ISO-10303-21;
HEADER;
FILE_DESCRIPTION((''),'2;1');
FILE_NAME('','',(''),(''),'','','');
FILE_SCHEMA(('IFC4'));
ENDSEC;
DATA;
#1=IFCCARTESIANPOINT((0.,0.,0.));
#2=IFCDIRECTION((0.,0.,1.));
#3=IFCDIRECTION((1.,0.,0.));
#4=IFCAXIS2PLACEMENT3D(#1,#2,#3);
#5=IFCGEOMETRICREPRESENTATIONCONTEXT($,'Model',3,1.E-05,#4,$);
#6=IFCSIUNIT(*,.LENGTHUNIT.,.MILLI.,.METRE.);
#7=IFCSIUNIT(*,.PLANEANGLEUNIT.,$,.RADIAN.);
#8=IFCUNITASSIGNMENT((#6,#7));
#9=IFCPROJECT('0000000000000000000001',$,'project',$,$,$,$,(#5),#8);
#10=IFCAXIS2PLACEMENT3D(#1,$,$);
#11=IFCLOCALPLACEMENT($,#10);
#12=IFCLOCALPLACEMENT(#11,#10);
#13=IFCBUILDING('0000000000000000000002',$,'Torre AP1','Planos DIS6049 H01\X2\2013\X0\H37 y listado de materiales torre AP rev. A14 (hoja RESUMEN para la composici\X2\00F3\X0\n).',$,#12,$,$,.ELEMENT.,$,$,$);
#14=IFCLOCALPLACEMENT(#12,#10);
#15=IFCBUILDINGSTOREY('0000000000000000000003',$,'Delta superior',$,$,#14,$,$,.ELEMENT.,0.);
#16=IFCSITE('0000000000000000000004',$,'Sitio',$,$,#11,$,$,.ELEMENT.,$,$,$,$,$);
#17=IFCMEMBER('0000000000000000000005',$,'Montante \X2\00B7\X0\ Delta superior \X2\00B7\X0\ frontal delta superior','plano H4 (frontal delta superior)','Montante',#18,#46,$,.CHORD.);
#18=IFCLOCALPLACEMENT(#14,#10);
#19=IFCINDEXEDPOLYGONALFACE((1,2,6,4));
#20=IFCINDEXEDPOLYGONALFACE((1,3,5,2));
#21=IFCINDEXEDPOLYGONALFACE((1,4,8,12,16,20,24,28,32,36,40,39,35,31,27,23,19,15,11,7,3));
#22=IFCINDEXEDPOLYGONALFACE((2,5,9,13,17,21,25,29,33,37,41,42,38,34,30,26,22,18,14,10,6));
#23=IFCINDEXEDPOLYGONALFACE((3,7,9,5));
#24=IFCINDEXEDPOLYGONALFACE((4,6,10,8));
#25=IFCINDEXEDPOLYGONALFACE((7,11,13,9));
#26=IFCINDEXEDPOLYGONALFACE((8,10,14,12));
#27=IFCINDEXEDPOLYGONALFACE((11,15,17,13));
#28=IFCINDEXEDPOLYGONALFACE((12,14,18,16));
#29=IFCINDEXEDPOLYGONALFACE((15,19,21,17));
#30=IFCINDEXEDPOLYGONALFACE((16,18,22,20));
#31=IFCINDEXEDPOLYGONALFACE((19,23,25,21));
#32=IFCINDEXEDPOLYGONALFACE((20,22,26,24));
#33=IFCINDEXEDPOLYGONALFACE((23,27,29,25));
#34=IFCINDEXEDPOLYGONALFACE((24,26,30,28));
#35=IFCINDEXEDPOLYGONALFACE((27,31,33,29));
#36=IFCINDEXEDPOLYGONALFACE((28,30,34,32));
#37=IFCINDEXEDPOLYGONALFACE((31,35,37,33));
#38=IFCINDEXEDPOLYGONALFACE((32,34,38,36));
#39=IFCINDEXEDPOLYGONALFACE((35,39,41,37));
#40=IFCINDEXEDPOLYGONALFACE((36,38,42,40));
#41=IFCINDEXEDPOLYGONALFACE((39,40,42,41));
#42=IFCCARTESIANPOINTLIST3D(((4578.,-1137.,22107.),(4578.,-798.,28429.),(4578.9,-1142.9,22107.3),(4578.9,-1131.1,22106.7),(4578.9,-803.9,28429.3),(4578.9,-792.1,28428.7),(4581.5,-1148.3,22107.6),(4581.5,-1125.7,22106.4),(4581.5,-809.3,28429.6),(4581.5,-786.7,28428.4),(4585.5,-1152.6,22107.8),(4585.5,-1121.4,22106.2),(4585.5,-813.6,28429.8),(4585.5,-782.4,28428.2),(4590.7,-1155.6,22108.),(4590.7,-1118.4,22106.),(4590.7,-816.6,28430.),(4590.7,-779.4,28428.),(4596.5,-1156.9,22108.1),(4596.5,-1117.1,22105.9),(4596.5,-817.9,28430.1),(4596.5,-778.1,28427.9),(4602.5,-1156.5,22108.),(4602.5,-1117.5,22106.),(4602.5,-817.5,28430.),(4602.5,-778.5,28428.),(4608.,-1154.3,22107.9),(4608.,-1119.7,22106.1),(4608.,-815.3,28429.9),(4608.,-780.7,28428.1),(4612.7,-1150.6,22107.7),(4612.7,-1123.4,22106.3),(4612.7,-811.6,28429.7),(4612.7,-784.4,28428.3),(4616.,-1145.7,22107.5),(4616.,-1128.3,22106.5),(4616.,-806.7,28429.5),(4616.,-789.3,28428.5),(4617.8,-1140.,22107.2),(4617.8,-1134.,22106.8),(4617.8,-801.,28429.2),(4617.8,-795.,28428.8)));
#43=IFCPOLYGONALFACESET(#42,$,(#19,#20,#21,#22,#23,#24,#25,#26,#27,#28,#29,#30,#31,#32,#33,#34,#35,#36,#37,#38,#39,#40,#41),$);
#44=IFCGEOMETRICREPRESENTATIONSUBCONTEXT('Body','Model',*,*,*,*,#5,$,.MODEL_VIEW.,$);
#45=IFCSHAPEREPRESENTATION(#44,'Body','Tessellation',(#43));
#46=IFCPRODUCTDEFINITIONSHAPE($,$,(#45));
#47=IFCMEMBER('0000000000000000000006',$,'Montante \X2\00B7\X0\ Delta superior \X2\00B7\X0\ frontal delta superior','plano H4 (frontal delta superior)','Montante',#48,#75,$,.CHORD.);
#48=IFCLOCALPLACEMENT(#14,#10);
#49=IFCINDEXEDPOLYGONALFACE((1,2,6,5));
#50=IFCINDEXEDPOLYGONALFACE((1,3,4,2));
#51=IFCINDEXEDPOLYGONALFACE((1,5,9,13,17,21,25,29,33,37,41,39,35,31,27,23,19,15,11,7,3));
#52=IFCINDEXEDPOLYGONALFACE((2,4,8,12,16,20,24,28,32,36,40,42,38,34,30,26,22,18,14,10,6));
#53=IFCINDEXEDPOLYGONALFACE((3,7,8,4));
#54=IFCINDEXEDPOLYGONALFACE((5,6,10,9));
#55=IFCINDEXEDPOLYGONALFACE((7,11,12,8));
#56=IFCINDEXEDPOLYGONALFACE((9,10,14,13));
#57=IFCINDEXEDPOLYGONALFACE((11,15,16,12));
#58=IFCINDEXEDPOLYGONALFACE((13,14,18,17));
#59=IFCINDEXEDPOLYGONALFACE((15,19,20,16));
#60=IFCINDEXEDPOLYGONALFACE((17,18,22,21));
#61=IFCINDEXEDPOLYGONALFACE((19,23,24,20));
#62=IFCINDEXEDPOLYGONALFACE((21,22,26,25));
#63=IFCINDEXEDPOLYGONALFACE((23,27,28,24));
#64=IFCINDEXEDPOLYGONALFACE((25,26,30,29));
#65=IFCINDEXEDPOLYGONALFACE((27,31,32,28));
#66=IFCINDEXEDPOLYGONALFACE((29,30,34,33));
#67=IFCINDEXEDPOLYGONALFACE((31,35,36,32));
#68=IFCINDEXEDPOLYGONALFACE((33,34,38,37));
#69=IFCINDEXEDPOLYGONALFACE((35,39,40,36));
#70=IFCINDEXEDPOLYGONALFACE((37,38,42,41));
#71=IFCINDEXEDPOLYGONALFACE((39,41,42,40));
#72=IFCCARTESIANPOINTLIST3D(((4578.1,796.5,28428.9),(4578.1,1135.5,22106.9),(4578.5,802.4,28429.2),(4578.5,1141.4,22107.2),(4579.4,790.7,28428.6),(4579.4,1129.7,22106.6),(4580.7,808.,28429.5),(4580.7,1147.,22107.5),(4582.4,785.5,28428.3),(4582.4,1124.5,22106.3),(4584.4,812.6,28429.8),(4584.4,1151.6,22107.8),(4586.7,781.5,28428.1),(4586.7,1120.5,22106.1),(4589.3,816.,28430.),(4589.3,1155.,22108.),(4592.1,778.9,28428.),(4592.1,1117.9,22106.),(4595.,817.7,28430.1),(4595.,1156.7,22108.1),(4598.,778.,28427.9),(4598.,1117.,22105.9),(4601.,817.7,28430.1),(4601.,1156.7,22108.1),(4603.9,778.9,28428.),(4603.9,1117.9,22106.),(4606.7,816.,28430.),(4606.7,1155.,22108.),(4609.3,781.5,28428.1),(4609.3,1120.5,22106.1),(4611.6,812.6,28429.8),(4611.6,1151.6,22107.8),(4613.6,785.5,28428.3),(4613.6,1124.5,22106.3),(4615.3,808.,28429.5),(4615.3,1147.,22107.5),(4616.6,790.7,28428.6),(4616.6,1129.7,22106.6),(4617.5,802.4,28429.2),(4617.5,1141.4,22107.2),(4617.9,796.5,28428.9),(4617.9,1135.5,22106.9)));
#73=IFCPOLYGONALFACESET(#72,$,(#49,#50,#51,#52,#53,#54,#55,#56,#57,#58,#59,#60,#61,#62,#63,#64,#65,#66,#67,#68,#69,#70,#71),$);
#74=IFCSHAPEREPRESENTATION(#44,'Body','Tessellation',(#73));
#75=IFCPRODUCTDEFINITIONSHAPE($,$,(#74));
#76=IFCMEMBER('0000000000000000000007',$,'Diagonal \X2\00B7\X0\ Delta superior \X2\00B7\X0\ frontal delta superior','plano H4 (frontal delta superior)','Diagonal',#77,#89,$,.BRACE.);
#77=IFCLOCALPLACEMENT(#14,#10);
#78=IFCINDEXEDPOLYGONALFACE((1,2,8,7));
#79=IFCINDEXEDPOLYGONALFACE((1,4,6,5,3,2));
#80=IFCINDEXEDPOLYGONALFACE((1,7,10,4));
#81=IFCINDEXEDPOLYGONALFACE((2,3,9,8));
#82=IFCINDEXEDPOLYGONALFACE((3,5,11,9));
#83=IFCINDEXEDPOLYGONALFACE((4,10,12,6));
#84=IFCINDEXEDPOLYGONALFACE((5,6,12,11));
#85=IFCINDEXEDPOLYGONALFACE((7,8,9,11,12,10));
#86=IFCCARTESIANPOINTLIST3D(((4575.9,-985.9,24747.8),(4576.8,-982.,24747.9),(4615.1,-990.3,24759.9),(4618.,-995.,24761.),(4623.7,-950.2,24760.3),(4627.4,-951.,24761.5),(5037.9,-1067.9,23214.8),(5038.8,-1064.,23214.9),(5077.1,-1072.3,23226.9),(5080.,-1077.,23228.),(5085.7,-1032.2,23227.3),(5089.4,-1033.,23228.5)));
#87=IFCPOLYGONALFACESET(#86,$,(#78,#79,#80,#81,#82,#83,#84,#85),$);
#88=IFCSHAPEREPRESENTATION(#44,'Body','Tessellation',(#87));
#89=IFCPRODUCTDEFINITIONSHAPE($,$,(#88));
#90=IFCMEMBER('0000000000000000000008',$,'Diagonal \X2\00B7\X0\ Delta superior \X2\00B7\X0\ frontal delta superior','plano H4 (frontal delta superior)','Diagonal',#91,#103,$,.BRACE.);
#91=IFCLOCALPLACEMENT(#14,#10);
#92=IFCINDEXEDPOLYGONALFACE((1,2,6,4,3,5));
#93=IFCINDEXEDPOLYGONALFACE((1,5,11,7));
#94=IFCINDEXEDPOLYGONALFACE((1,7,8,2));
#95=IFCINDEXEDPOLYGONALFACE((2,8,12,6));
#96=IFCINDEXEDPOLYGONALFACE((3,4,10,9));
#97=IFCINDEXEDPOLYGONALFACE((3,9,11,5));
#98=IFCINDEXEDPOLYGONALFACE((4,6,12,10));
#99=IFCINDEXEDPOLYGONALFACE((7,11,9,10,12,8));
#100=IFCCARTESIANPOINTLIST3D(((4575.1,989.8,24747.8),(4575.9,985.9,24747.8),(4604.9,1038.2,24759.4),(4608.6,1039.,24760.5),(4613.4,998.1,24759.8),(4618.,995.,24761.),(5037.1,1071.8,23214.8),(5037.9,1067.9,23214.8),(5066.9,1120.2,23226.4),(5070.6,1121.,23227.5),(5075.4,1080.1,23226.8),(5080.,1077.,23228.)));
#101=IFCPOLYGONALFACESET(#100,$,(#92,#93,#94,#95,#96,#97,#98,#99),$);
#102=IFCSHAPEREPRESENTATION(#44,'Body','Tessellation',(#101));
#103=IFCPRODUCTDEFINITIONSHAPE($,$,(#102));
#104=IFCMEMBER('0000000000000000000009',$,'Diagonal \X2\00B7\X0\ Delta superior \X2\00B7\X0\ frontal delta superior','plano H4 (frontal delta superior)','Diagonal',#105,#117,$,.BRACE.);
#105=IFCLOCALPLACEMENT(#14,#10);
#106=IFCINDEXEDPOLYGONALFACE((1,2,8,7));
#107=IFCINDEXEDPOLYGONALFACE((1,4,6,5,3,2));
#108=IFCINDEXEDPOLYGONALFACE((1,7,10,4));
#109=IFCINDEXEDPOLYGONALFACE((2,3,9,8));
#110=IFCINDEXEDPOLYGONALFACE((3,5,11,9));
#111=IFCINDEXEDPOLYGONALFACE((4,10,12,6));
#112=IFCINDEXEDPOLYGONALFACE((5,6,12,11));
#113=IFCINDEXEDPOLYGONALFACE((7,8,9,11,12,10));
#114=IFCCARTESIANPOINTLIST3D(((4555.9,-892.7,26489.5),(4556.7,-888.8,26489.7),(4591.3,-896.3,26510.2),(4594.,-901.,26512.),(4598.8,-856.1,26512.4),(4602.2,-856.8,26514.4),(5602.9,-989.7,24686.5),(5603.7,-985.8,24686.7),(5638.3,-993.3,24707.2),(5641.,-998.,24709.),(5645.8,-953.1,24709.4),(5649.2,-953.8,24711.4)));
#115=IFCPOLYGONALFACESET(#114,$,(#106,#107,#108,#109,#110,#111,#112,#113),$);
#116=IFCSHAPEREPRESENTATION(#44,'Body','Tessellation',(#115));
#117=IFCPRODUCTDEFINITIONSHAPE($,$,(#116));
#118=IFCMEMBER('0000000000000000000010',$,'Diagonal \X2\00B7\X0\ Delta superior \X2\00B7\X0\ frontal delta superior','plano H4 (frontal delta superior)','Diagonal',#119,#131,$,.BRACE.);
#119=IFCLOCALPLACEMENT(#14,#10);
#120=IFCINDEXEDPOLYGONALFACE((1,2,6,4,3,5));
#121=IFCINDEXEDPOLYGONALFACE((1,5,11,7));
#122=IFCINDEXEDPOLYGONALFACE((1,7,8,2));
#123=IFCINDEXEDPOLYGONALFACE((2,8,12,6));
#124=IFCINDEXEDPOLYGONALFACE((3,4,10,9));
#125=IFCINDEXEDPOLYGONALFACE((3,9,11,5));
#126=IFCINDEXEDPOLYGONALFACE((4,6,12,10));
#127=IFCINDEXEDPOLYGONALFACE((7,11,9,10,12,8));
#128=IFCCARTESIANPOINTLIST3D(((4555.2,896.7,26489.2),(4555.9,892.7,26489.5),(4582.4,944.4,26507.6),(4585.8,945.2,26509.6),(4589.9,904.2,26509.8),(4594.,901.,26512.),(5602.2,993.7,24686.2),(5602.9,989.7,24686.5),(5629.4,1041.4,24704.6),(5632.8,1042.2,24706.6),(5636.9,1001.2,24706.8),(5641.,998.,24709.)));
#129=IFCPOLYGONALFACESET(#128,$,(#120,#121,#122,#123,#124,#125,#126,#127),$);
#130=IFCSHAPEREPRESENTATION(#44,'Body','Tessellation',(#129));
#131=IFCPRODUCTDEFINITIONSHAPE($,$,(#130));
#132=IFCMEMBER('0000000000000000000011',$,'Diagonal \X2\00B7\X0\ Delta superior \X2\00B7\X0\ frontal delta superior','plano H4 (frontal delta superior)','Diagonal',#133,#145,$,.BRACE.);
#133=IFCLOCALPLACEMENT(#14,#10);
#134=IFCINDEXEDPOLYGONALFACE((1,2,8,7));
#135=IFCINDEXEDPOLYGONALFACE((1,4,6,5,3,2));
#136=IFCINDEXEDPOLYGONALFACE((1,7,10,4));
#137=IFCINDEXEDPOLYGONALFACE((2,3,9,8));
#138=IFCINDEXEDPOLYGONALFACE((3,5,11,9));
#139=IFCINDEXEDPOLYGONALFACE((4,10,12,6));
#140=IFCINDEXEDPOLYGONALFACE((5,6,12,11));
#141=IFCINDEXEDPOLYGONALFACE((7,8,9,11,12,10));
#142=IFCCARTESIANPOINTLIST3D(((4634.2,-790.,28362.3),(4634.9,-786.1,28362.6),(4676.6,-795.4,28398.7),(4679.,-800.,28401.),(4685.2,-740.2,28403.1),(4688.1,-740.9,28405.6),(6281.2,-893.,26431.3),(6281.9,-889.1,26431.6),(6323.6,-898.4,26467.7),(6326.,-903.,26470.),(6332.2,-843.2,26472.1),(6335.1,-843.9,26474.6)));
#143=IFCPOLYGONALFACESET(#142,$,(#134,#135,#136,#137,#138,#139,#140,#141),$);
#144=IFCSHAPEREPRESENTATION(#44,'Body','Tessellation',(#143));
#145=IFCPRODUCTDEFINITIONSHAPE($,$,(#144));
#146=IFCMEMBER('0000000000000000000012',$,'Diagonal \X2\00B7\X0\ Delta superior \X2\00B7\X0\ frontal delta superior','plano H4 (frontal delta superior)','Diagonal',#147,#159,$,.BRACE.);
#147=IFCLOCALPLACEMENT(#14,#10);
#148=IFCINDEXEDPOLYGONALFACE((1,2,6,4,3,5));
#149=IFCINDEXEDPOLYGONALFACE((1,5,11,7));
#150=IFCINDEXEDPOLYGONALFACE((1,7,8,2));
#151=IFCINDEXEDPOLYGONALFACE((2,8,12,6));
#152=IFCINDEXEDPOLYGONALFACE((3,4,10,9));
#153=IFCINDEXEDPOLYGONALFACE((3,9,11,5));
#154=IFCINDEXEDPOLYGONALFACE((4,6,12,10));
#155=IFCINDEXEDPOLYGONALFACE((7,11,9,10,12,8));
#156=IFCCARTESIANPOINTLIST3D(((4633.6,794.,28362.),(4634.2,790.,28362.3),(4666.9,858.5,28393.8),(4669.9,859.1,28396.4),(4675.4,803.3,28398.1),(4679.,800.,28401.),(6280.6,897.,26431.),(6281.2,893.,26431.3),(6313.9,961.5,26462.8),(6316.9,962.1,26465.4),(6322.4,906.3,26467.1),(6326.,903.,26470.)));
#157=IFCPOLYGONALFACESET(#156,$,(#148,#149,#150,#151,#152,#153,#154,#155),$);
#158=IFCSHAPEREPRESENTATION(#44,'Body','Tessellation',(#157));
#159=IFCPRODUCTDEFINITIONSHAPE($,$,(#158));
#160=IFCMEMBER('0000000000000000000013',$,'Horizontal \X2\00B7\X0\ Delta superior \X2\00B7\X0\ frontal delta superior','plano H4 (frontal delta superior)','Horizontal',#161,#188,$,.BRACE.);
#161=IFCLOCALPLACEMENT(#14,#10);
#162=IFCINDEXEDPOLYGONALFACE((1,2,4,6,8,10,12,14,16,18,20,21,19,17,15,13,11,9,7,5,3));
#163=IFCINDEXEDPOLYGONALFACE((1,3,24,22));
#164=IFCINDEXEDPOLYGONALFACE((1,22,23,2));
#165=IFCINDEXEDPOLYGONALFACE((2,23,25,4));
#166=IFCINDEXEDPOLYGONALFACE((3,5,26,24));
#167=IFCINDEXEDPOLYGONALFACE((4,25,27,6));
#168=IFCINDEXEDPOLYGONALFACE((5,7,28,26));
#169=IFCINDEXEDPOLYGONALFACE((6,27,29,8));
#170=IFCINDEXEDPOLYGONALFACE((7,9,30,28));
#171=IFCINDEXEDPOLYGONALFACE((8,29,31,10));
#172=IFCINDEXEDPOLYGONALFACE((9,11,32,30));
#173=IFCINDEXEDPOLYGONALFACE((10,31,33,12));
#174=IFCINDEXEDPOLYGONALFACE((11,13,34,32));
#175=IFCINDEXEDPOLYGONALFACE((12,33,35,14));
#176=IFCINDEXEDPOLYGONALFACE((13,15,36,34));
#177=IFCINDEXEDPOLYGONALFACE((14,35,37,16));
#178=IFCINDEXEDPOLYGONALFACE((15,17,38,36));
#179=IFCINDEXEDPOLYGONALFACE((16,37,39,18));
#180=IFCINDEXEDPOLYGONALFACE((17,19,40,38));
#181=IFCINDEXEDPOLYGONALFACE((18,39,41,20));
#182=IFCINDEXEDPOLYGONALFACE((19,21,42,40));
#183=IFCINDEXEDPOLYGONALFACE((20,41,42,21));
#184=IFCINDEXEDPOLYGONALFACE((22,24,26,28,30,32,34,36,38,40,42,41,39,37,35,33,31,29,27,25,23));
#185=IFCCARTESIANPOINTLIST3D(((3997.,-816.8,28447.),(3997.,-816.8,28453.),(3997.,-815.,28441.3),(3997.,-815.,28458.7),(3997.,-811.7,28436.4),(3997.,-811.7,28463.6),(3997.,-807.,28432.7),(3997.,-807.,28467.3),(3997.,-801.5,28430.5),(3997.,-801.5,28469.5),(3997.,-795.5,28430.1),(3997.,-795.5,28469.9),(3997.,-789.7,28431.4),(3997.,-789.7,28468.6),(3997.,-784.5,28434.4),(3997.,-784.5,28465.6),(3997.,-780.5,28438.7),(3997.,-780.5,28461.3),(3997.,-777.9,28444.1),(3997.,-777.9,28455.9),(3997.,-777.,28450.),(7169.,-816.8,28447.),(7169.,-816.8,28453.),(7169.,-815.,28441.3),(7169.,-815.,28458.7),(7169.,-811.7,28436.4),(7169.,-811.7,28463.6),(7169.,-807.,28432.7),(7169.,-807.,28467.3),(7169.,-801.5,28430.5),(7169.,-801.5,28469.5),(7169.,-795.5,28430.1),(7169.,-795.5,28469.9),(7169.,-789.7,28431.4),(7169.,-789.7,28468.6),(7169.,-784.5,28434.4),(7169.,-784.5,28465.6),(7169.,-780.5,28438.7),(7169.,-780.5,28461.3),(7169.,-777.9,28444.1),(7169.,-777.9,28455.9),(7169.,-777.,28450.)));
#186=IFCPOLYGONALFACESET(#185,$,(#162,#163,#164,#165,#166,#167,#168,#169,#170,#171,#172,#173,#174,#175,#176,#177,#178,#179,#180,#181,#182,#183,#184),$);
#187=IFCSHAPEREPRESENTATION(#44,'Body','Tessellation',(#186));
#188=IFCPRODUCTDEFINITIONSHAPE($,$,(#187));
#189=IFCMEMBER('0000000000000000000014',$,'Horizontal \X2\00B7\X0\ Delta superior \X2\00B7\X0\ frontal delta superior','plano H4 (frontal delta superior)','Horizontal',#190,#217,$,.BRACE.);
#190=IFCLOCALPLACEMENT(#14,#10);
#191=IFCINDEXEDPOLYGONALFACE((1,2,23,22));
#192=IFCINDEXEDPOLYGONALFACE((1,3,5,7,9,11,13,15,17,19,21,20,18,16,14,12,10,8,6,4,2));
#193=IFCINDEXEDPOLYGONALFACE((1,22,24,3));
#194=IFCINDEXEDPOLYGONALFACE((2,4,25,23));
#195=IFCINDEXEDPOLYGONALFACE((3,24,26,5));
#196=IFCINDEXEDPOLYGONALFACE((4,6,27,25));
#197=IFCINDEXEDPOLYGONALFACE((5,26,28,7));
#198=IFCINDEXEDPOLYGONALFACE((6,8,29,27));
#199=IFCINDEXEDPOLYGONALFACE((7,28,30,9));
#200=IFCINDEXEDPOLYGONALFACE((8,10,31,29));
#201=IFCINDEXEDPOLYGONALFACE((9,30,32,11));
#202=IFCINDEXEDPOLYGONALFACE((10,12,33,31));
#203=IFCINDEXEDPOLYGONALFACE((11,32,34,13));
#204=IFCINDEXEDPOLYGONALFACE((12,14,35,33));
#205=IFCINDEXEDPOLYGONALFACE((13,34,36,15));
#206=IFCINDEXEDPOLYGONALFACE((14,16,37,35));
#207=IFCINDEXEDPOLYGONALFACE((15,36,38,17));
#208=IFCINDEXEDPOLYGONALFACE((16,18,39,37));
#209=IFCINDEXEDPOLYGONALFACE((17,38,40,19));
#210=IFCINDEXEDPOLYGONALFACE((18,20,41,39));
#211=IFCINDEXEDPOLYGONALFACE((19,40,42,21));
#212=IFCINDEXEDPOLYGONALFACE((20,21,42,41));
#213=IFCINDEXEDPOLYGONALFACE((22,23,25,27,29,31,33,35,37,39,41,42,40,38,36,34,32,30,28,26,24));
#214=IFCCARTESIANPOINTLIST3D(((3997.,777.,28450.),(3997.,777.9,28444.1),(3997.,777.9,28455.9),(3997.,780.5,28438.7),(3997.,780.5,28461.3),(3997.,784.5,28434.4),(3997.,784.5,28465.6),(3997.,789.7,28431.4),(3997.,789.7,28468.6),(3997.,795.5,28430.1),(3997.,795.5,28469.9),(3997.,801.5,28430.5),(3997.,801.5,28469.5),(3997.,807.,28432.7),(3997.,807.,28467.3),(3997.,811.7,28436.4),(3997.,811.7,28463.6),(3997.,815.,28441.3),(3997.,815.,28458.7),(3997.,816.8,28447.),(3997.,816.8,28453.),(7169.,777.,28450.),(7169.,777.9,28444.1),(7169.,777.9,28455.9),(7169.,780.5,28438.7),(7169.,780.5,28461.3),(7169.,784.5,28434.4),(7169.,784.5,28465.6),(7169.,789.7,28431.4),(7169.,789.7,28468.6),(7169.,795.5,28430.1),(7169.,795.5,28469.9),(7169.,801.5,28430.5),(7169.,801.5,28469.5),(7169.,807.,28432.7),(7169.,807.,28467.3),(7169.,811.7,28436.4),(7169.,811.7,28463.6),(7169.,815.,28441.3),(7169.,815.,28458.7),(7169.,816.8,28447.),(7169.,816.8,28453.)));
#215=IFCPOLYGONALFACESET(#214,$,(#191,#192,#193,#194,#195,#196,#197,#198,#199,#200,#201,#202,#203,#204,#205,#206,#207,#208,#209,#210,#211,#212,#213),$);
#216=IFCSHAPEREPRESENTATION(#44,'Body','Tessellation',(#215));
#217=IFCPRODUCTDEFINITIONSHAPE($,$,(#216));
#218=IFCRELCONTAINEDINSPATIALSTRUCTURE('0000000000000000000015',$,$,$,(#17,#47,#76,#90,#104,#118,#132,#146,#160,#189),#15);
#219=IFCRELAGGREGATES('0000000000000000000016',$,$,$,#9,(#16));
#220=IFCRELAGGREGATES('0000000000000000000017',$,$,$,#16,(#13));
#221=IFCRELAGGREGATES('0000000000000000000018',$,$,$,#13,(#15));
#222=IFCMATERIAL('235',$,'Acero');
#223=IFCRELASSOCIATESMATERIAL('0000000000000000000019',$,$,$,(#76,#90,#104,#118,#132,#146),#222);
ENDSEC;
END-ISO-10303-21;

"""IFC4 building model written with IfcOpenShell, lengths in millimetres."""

from ifc_helpers import new_model, si_unit, frame, frame_2d, origin, origin_with_axes, place, context, subcontext, project, spatial, circle, l_section, extrude, material, element, save


model = new_model("IFC4")

# Units and contexts
model_context = context("Model", 3, precision=1e-05, world=origin_with_axes())
body_context = subcontext(model_context, "Body", "Model", "MODEL_VIEW")
ifc_project = project(units=[si_unit("LENGTHUNIT", "METRE", prefix="MILLI"), si_unit("PLANEANGLEUNIT", "RADIAN")], contexts=[model_context])

# Site, building, storey
site_placement = place(None, origin())
site = spatial("IfcSite", under=ifc_project, at=site_placement, Name="Sitio", CompositionType="ELEMENT")
building_placement = place(site_placement, origin())
building = spatial("IfcBuilding", under=site, at=building_placement, Name="Torre AP1", Description="Planos DIS6049 H01–H37 y listado de materiales torre AP rev. A14 (hoja RESUMEN para la composición).", CompositionType="ELEMENT")
storey_placement = place(building_placement, origin())
storey = spatial("IfcBuildingStorey", under=building, at=storey_placement, Name="Delta superior", CompositionType="ELEMENT", Elevation=0.0)

# Members
for number, where, z_axis, x_axis, name in (
    (1, (4598.0, -798.0, 28429.0), (0.0, -0.053545, -0.998565), (-1.0, 0.0, 0.0), "Montante · Delta superior · frontal delta superior"),
    (2, (4598.0, 798.0, 28429.0), (0.0, 0.053545, -0.998565), (0.0, -0.998565, -0.053545), "Montante · Delta superior · frontal delta superior"),
):
    element("IfcMember", number, at=place(storey_placement, frame(where, z_axis=z_axis, x_axis=x_axis)), inside=storey, Name=name, Description="plano H4 (frontal delta superior)", ObjectType="Montante", PredefinedType="CHORD", context=body_context, shape_type="SweptSolid", body=[
        extrude(circle(Radius=20.0), None, (0.0, 0.0, 1.0), 6331.1),
    ])
ifc_material_1 = material(Name="235", Category="Acero")
for number, where, z_axis, x_axis, name in (
    (3, (4618.0, -995.0, 24761.0), (0.288173, -0.051148, -0.956211), (-0.934509, 0.202848, -0.292483), "Diagonal · Delta superior · frontal delta superior"),
    (4, (4618.0, 995.0, 24761.0), (0.288173, 0.051148, -0.956211), (-0.934509, -0.202848, -0.292483), "Diagonal · Delta superior · frontal delta superior"),
):
    element("IfcMember", number, at=place(storey_placement, frame(where, z_axis=z_axis, x_axis=x_axis)), inside=storey, material=ifc_material_1, Name=name, Description="plano H4 (frontal delta superior)", ObjectType="Diagonal", PredefinedType="BRACE", context=body_context, shape_type="SweptSolid", body=[
        extrude(l_section(Depth=45.0, Width=45.0, Thickness=4.0, at=frame_2d((22.5, 22.5))), None, (0.0, 0.0, 1.0), 1603.2),
    ])
for number, where, z_axis, x_axis, name in (
    (5, (4594.0, -901.0, 26512.0), (0.501628, -0.046474, -0.863834), (-0.845685, 0.183933, -0.500984), "Diagonal · Delta superior · frontal delta superior"),
    (6, (4594.0, 901.0, 26512.0), (0.501628, 0.046474, -0.863834), (-0.845685, -0.183933, -0.500984), "Diagonal · Delta superior · frontal delta superior"),
):
    element("IfcMember", number, at=place(storey_placement, frame(where, z_axis=z_axis, x_axis=x_axis)), inside=storey, material=ifc_material_1, Name=name, Description="plano H4 (frontal delta superior)", ObjectType="Diagonal", PredefinedType="BRACE", context=body_context, shape_type="SweptSolid", body=[
        extrude(l_section(Depth=45.0, Width=45.0, Thickness=4.0, at=frame_2d((22.5, 22.5))), None, (0.0, 0.0, 1.0), 2087.2),
    ])
for number, where, z_axis, x_axis, name in (
    (7, (4679.0, -800.0, 28401.0), (0.648406, -0.04055, -0.760214), (-0.745871, 0.166153, -0.645035), "Diagonal · Delta superior · frontal delta superior"),
    (8, (4679.0, 800.0, 28401.0), (0.648406, 0.04055, -0.760214), (-0.745871, -0.166153, -0.645035), "Diagonal · Delta superior · frontal delta superior"),
):
    element("IfcMember", number, at=place(storey_placement, frame(where, z_axis=z_axis, x_axis=x_axis)), inside=storey, material=ifc_material_1, Name=name, Description="plano H4 (frontal delta superior)", ObjectType="Diagonal", PredefinedType="BRACE", context=body_context, shape_type="SweptSolid", body=[
        extrude(l_section(Depth=60.0, Width=60.0, Thickness=4.0, at=frame_2d((30.0, 30.0))), None, (0.0, 0.0, 1.0), 2540.1),
    ])
for number, where, z_axis, x_axis, name in (
    (9, (3997.0, -797.0, 28450.0), (1.0, 0.0, 0.0), (0.0, 1.0, 0.0), "Horizontal · Delta superior · frontal delta superior"),
    (10, (3997.0, 797.0, 28450.0), (1.0, 0.0, 0.0), (0.0, -1.0, 0.0), "Horizontal · Delta superior · frontal delta superior"),
):
    element("IfcMember", number, at=place(storey_placement, frame(where, z_axis=z_axis, x_axis=x_axis)), inside=storey, Name=name, Description="plano H4 (frontal delta superior)", ObjectType="Horizontal", PredefinedType="BRACE", context=body_context, shape_type="SweptSolid", body=[
        extrude(circle(Radius=20.0), None, (0.0, 0.0, 1.0), 3172.0),
    ])

save(model, "model.ifc")
